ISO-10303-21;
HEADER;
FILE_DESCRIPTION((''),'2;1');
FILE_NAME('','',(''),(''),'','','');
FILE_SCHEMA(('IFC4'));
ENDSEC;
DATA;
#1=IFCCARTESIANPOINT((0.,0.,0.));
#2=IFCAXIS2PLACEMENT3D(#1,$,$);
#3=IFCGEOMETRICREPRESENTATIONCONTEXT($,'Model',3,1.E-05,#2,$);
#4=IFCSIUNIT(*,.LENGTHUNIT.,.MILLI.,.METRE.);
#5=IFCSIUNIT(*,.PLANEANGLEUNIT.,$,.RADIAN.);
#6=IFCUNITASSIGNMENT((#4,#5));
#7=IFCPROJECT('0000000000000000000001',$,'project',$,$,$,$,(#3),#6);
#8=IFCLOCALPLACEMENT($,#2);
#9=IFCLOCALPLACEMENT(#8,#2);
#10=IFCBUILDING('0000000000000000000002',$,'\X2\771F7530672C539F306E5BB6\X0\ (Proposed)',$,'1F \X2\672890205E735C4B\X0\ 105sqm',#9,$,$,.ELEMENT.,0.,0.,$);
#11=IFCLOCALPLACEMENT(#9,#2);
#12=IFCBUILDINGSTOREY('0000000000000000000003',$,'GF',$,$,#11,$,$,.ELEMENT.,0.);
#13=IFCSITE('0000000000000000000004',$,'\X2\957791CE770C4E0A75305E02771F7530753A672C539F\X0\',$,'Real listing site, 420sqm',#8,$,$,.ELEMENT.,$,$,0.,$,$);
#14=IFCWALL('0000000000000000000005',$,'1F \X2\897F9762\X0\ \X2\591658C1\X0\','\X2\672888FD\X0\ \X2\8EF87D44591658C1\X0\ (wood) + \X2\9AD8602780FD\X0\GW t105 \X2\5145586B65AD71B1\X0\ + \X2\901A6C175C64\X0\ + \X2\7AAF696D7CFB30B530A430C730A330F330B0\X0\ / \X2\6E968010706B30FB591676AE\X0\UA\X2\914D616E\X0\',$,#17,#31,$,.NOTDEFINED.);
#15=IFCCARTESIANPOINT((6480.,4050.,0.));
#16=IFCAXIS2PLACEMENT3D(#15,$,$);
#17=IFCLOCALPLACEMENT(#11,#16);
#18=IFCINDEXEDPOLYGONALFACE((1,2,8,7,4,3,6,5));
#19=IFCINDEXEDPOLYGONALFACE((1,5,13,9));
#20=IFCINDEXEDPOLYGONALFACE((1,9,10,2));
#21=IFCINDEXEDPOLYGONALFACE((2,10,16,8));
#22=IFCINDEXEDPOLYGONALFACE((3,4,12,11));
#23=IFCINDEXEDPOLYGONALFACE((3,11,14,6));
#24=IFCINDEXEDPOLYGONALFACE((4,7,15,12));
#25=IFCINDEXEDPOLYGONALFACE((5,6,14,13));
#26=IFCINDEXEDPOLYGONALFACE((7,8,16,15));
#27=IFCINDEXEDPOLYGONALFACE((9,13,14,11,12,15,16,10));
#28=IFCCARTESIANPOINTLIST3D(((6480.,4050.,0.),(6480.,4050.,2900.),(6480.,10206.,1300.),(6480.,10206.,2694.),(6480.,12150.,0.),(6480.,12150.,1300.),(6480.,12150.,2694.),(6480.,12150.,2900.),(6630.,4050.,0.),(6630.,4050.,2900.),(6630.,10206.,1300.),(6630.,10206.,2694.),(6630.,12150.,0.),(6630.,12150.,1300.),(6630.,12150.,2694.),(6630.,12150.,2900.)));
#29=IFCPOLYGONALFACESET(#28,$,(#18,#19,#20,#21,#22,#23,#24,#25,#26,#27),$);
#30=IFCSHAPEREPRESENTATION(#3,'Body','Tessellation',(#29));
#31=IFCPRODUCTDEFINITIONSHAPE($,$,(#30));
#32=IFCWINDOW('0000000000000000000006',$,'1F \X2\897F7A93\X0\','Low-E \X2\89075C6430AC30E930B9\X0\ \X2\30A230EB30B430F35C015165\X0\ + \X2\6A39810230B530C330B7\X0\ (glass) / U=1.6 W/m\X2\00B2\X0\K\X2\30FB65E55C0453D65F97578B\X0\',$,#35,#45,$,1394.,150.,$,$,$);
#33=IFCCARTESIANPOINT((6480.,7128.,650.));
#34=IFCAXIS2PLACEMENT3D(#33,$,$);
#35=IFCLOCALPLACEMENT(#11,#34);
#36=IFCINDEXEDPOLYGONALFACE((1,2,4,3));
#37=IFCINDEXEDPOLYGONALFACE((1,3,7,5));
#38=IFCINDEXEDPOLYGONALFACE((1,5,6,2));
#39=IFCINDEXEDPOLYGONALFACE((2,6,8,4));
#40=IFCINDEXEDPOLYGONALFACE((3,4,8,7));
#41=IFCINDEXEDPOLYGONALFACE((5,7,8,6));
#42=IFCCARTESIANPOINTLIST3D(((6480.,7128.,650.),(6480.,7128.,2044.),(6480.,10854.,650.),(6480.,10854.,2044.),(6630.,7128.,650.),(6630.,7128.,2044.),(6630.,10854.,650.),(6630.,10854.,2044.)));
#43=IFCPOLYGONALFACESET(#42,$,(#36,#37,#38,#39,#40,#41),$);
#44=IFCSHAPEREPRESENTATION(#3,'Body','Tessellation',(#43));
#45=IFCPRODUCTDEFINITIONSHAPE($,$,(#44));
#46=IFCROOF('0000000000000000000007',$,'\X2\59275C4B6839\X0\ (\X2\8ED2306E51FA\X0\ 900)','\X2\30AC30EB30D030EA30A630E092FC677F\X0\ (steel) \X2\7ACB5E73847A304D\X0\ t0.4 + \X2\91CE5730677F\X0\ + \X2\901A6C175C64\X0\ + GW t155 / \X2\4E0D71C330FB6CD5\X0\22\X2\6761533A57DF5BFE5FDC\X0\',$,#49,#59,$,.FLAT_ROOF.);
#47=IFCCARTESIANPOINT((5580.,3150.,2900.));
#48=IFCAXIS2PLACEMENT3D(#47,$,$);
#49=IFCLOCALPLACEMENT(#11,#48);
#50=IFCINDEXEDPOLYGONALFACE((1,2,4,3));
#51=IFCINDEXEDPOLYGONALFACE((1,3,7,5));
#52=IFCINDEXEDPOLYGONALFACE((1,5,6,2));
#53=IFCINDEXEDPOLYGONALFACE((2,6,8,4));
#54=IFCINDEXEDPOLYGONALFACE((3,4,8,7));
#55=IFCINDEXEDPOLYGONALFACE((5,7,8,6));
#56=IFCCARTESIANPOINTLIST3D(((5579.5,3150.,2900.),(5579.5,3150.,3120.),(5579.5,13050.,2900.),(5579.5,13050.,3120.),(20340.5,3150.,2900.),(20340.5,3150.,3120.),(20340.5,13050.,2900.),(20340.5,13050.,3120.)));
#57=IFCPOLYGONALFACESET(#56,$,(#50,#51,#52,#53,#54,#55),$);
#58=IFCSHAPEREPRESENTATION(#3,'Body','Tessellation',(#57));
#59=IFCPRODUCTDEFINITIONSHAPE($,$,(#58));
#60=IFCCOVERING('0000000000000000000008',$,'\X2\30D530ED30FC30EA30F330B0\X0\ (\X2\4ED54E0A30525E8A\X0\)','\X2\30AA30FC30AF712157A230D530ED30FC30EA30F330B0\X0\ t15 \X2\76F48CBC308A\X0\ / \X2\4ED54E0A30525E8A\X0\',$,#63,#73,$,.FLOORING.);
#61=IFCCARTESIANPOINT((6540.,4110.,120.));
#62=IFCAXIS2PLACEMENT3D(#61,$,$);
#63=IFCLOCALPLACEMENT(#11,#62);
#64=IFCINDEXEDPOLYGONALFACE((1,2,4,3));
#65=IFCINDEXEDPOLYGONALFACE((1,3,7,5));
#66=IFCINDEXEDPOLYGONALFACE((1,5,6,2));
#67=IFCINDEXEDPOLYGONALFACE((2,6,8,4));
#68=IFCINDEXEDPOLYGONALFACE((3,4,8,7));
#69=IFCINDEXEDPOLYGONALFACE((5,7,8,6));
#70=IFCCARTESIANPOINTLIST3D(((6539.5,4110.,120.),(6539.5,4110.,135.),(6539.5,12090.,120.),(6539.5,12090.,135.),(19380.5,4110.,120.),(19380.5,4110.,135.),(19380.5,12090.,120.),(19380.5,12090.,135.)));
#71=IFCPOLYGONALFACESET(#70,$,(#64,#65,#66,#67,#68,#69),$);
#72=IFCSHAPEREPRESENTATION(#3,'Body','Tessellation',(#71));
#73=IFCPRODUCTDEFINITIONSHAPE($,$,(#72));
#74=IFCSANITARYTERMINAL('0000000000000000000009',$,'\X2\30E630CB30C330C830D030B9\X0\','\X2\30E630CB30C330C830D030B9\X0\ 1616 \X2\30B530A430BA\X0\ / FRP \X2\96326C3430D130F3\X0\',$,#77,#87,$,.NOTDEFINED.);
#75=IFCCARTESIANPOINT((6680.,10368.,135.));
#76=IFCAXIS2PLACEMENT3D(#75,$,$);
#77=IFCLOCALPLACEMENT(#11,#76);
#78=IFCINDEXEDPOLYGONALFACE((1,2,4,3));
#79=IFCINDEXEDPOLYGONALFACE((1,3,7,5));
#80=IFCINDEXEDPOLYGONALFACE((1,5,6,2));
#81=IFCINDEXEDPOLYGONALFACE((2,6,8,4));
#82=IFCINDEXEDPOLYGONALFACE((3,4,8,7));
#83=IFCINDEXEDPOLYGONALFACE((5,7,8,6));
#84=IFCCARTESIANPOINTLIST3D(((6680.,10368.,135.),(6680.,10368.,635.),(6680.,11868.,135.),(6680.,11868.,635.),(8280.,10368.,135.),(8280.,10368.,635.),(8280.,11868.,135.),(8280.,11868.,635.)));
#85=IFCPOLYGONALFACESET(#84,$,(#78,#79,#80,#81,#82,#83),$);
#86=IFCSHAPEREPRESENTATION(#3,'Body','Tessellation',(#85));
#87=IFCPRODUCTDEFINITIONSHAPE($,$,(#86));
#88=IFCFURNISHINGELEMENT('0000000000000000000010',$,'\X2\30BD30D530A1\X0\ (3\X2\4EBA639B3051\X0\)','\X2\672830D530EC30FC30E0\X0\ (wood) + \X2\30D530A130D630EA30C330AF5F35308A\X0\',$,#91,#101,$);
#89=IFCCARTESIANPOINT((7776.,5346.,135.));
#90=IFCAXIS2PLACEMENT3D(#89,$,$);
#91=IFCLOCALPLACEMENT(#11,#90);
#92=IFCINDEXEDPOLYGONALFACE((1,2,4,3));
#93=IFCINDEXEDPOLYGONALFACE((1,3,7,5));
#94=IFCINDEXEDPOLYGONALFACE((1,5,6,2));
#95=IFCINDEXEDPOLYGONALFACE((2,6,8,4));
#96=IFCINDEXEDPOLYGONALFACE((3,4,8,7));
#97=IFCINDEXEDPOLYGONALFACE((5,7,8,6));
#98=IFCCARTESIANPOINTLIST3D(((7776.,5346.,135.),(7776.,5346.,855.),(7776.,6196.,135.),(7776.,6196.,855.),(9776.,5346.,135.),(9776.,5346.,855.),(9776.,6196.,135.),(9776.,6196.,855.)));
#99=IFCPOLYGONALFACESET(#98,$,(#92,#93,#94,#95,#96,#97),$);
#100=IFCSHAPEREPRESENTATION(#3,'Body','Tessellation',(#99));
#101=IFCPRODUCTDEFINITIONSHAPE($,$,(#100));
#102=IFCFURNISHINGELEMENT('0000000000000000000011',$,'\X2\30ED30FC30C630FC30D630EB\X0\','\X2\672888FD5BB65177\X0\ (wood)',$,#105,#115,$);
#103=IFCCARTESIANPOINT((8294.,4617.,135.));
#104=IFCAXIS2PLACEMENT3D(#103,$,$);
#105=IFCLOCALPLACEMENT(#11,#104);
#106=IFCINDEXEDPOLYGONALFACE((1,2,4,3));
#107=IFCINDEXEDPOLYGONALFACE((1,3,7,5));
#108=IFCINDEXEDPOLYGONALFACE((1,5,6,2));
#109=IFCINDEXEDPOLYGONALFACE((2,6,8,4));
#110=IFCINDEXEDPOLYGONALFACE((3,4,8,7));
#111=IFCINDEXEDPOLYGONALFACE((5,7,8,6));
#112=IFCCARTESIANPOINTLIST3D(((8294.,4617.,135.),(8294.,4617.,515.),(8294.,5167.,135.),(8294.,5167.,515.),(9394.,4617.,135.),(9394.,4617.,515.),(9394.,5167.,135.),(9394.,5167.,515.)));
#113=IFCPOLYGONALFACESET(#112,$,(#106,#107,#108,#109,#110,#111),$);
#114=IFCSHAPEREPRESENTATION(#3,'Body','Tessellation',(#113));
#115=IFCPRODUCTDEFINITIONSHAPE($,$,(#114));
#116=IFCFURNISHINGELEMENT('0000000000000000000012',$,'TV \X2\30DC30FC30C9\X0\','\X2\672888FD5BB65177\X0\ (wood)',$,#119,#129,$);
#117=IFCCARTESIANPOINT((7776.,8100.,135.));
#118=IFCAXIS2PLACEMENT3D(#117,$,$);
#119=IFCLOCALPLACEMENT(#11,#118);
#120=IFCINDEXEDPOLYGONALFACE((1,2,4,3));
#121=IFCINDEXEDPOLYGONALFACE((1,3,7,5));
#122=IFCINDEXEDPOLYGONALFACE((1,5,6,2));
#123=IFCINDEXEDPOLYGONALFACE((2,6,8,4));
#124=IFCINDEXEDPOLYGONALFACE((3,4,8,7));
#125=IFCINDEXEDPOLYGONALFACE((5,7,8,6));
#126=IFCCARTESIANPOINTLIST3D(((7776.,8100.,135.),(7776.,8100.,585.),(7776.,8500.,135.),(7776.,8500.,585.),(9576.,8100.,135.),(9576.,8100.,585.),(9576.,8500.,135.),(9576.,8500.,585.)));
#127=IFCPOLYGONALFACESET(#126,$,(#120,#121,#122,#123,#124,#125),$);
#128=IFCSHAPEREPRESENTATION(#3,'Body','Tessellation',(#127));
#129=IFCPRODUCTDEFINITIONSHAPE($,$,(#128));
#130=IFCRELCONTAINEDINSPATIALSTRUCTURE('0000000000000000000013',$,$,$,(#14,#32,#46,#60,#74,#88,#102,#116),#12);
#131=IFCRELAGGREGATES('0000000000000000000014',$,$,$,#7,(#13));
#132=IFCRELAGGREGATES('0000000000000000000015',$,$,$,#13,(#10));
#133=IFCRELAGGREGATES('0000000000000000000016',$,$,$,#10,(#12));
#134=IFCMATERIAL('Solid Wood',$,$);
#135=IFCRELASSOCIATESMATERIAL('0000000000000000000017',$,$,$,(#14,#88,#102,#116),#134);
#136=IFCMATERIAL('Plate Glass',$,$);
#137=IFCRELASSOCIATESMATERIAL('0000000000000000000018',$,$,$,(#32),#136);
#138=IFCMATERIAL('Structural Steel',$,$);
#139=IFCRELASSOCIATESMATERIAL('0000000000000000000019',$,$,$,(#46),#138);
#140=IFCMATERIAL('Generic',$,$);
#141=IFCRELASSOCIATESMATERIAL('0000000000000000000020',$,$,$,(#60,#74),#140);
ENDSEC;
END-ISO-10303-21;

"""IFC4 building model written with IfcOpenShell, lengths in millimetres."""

from ifc_helpers import new_model, si_unit, frame, frame_2d, origin, place, context, project, spatial, rectangle, extrude, material, element, fill, save


model = new_model("IFC4")

# Units and contexts
model_context = context("Model", 3, precision=1e-05, world=origin())
ifc_project = project(units=[si_unit("LENGTHUNIT", "METRE", prefix="MILLI"), si_unit("PLANEANGLEUNIT", "RADIAN")], contexts=[model_context])

# Site, building, storey
site_placement = place(None, origin())
site = spatial("IfcSite", under=ifc_project, at=site_placement, Name="長野県上田市真田町本原", ObjectType="Real listing site, 420sqm", CompositionType="ELEMENT", RefElevation=0.0)
building_placement = place(site_placement, origin())
building = spatial("IfcBuilding", under=site, at=building_placement, Name="真田本原の家 (Proposed)", ObjectType="1F 木造平屋 105sqm", CompositionType="ELEMENT", ElevationOfRefHeight=0.0, ElevationOfTerrain=0.0)
storey_placement = place(building_placement, origin())
storey = spatial("IfcBuildingStorey", under=building, at=storey_placement, Name="GF", CompositionType="ELEMENT", Elevation=0.0)

# Shared definitions
ifc_material_1 = material(Name="Solid Wood")

# Shared definitions
ifc_material_2 = material(Name="Plate Glass")

# Wall, opening, window
wall_1_placement = place(storey_placement, frame((6480.0, 4050.0, 0.0)))
wall_1 = element("IfcWall", 1, at=wall_1_placement, inside=storey, material=ifc_material_1, Name="1F 西面 外壁", Description="木製 軸組外壁 (wood) + 高性能GW t105 充填断熱 + 通気層 + 窯業系サイディング / 準耐火・外皮UA配慮", PredefinedType="NOTDEFINED", context=model_context, shape_type="SweptSolid", body=[
    extrude(rectangle(XDim=150.0, YDim=8100.0, at=frame_2d((75.0, 4050.0))), frame((6480.0, 4050.0, 0.0)), (0.0, 0.0, 1.0), 2900.0),
])
opening_1_placement = place(storey_placement, frame((6480.0, 7128.0, 650.0)))
opening_1 = element("IfcOpeningElement", 2, at=opening_1_placement, cuts=wall_1, PredefinedType="NOTDEFINED", context=model_context, shape_type="SweptSolid", body=[
    extrude(rectangle(XDim=150.0, YDim=3726.0, at=frame_2d((75.0, 1863.0))), frame((6480.0, 7128.0, 650.0)), (0.0, 0.0, 1.0), 1394.0),
])
window_1_placement = place(storey_placement, frame((6480.0, 7128.0, 650.0)))
window_1 = element("IfcWindow", 3, at=window_1_placement, inside=storey, material=ifc_material_2, Name="1F 西窓", Description="Low-E 複層ガラス アルゴン封入 + 樹脂サッシ (glass) / U=1.6 W/m²K・日射取得型", OverallHeight=1394.0, OverallWidth=150.0, context=model_context, shape_type="SweptSolid", body=[
    extrude(rectangle(XDim=150.0, YDim=3726.0, at=frame_2d((75.0, 1863.0))), frame((6480.0, 7128.0, 650.0)), (0.0, 0.0, 1.0), 1394.0),
])
fill(opening_1, window_1)

# Roof
ifc_material_3 = material(Name="Structural Steel")
roof_placement = place(storey_placement, frame((5580.0, 3150.0, 2900.0)))
element("IfcRoof", 4, at=roof_placement, inside=storey, material=ifc_material_3, Name="大屋根 (軒の出 900)", Description="ガルバリウム鋼板 (steel) 立平葺き t0.4 + 野地板 + 通気層 + GW t155 / 不燃・法22条区域対応", PredefinedType="FLAT_ROOF", context=model_context, shape_type="SweptSolid", body=[
    extrude(rectangle(XDim=14761.0, YDim=9900.0, at=frame_2d((7380.0, 4950.0))), frame((5580.0, 3150.0, 2900.0)), (0.0, 0.0, 1.0), 220.0),
])

# Covering
ifc_material_4 = material(Name="Generic")
covering_placement = place(storey_placement, frame((6540.0, 4110.0, 120.0)))
element("IfcCovering", 5, at=covering_placement, inside=storey, material=ifc_material_4, Name="フローリング (仕上げ床)", Description="オーク無垢フローリング t15 直貼り / 仕上げ床", PredefinedType="FLOORING", context=model_context, shape_type="SweptSolid", body=[
    extrude(rectangle(XDim=12841.0, YDim=7980.0, at=frame_2d((6420.0, 3990.0))), frame((6540.0, 4110.0, 120.0)), (0.0, 0.0, 1.0), 15.0),
])

# Sanitary terminal
sanitary_terminal_placement = place(storey_placement, frame((6680.0, 10368.0, 135.0)))
element("IfcSanitaryTerminal", 6, at=sanitary_terminal_placement, inside=storey, material=ifc_material_4, Name="ユニットバス", Description="ユニットバス 1616 サイズ / FRP 防水パン", PredefinedType="NOTDEFINED", context=model_context, shape_type="SweptSolid", body=[
    extrude(rectangle(XDim=1600.0, YDim=1500.0, at=frame_2d((800.0, 750.0))), frame((6680.0, 10368.0, 135.0)), (0.0, 0.0, 1.0), 500.0),
])

# Furnishing elements
furnishing_1_placement = place(storey_placement, frame((7776.0, 5346.0, 135.0)))
element("IfcFurnishingElement", 7, at=furnishing_1_placement, inside=storey, material=ifc_material_1, Name="ソファ (3人掛け)", Description="木フレーム (wood) + ファブリック張り", context=model_context, shape_type="SweptSolid", body=[
    extrude(rectangle(XDim=2000.0, YDim=850.0, at=frame_2d((1000.0, 425.0))), frame((7776.0, 5346.0, 135.0)), (0.0, 0.0, 1.0), 720.0),
])
furnishing_2_placement = place(storey_placement, frame((8294.0, 4617.0, 135.0)))
element("IfcFurnishingElement", 8, at=furnishing_2_placement, inside=storey, material=ifc_material_1, Name="ローテーブル", Description="木製家具 (wood)", context=model_context, shape_type="SweptSolid", body=[
    extrude(rectangle(XDim=1100.0, YDim=550.0, at=frame_2d((550.0, 275.0))), frame((8294.0, 4617.0, 135.0)), (0.0, 0.0, 1.0), 380.0),
])
furnishing_3_placement = place(storey_placement, frame((7776.0, 8100.0, 135.0)))
element("IfcFurnishingElement", 9, at=furnishing_3_placement, inside=storey, material=ifc_material_1, Name="TV ボード", Description="木製家具 (wood)", context=model_context, shape_type="SweptSolid", body=[
    extrude(rectangle(XDim=1800.0, YDim=400.0, at=frame_2d((900.0, 200.0))), frame((7776.0, 8100.0, 135.0)), (0.0, 0.0, 1.0), 450.0),
])

save(model, "model.ifc")
